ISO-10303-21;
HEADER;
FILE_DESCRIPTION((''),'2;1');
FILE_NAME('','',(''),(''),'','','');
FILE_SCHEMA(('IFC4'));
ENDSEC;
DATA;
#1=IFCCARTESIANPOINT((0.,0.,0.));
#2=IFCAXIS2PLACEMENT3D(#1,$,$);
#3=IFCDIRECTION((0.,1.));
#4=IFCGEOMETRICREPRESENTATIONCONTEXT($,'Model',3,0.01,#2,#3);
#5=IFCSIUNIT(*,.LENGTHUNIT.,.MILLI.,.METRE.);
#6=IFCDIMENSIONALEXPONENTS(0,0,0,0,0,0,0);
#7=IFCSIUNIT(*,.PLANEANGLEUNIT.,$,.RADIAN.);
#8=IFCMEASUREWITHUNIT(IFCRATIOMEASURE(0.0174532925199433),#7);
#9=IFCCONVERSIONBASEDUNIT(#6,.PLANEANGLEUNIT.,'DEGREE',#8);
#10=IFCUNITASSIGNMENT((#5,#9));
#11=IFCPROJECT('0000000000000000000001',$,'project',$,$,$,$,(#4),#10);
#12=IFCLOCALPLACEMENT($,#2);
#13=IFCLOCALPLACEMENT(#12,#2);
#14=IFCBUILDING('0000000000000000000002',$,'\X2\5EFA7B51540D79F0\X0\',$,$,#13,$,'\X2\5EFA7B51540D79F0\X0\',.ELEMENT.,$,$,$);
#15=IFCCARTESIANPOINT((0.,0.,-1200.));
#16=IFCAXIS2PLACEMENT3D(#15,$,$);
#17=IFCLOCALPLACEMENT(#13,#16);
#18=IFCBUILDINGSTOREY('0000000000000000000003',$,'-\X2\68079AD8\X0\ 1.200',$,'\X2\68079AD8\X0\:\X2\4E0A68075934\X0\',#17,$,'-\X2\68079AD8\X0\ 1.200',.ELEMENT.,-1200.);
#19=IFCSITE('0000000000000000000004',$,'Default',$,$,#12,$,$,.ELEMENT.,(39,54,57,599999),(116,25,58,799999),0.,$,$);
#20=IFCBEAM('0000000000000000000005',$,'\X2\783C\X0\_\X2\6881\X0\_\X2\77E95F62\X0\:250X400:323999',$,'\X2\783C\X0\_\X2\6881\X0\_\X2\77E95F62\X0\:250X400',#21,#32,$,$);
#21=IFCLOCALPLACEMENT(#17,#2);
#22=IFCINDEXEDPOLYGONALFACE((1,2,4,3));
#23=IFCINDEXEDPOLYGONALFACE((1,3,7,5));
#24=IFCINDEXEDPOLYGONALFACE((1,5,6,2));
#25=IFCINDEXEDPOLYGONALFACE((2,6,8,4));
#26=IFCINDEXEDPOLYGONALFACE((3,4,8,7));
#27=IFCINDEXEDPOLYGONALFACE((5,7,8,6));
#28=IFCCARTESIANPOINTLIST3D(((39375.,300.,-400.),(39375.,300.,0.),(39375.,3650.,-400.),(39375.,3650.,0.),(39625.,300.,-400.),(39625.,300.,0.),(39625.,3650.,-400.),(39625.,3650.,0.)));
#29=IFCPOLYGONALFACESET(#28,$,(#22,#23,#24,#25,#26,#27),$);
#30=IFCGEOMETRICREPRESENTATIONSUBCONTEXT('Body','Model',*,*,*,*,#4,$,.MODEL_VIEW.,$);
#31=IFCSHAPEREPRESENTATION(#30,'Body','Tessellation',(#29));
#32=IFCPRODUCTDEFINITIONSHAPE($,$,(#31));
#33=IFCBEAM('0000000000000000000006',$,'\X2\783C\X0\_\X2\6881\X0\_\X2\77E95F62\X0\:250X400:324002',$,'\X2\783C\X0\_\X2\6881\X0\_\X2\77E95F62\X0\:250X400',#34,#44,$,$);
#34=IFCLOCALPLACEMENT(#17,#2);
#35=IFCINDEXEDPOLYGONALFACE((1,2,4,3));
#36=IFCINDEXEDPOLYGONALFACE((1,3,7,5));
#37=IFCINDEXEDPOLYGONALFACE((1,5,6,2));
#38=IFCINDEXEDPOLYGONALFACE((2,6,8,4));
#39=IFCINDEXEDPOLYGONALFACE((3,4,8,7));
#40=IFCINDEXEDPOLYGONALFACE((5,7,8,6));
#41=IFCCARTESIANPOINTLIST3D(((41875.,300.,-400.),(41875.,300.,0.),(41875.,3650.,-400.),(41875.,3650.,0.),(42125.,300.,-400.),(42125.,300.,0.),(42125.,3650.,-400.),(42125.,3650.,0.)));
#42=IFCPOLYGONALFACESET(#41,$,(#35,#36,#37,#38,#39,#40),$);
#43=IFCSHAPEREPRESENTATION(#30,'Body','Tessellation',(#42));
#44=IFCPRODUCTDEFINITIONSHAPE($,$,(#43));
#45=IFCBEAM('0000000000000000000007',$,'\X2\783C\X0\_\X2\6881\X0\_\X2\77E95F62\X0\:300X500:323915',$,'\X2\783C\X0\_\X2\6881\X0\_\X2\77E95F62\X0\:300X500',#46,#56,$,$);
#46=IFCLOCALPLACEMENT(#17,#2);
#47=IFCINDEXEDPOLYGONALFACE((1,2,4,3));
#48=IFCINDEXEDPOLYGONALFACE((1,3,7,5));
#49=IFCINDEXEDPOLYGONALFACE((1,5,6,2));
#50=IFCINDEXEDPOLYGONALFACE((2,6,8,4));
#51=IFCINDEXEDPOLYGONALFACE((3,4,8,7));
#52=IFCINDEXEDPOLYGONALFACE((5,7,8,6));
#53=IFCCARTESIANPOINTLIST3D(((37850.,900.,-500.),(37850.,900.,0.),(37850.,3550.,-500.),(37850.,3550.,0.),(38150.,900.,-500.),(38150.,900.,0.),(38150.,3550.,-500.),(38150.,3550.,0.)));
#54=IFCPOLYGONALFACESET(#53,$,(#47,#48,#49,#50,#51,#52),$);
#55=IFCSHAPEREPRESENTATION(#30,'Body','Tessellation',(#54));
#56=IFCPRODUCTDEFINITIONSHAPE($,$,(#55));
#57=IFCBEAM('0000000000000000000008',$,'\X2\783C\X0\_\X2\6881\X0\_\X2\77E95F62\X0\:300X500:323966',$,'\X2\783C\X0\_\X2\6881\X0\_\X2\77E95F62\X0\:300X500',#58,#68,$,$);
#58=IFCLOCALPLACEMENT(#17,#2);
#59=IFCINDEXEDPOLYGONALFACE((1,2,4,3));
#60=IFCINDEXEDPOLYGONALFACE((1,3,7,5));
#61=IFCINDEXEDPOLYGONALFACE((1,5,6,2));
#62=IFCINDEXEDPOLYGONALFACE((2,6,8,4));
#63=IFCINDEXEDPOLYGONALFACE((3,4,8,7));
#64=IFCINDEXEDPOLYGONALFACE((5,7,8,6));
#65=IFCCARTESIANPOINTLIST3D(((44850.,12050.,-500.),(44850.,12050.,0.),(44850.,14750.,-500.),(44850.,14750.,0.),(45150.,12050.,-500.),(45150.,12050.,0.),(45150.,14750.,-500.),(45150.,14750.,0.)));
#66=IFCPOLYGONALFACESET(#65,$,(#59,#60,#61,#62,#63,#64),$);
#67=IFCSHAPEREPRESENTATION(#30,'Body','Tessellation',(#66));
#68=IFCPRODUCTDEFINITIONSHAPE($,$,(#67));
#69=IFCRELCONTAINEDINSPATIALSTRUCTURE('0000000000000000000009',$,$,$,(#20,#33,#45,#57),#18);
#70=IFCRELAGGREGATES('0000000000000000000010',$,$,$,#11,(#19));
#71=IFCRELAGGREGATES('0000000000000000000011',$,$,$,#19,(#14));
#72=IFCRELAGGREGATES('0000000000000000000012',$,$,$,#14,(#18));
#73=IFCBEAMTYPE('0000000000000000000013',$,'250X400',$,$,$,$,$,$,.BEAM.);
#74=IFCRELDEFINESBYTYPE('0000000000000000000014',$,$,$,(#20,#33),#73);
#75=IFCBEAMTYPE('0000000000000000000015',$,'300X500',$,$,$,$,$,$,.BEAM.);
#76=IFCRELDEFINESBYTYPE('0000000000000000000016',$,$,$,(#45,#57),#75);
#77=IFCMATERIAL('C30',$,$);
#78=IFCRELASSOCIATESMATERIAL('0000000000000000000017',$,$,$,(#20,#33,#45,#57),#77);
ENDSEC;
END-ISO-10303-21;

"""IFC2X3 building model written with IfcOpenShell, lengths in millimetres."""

from ifc_helpers import new_model, entity, si_unit, converted_unit, direction, frame, frame_2d, origin, place, context, subcontext, project, spatial, rectangle, extrude, material, type_object, element, save


model = new_model("IFC2X3")

# Units and contexts
model_context = context("Model", 3, precision=0.01, world=origin(), true_north=direction((0.0, 1.0)))
body_context = subcontext(model_context, "Body", "Model", "MODEL_VIEW")
ifc_project = project(units=[si_unit("LENGTHUNIT", "METRE", prefix="MILLI"), converted_unit("PLANEANGLEUNIT", "DEGREE", entity("IfcRatioMeasure", 0.0174532925199433), si_unit("PLANEANGLEUNIT", "RADIAN"), dimensions=[0, 0, 0, 0, 0, 0, 0])], contexts=[model_context])

# Site, building, storey
site_placement = place(None, origin())
site = spatial("IfcSite", under=ifc_project, at=site_placement, Name="Default", CompositionType="ELEMENT", RefLatitude=(39, 54, 57, 599999), RefLongitude=(116, 25, 58, 799999), RefElevation=0.0)
building_placement = place(site_placement, origin())
building = spatial("IfcBuilding", under=site, at=building_placement, Name="建筑名称", LongName="建筑名称", CompositionType="ELEMENT")
storey_placement = place(building_placement, frame((0.0, 0.0, -1200.0)))
storey = spatial("IfcBuildingStorey", under=building, at=storey_placement, Name="-标高 1.200", ObjectType="标高:上标头", LongName="-标高 1.200", CompositionType="ELEMENT", Elevation=-1200.0)

# Beams
ifc_material_1 = material(Name="C30")
beam_type_1 = type_object("IfcBeamType", Name="250X400", PredefinedType="BEAM")
beam_1_placement = place(storey_placement, frame((39500.0, 0.0, 0.0), z_axis=(0.0, 0.0, 1.0), x_axis=(0.0, 1.0, 0.0)))
element("IfcBeam", 1, at=beam_1_placement, inside=storey, type_object=beam_type_1, material=ifc_material_1, Name="砼_梁_矩形:250X400:323999", ObjectType="砼_梁_矩形:250X400", context=body_context, shape_type="SweptSolid", body=[
    extrude(rectangle(XDim=400.0, YDim=250.0, at=frame_2d((0.0, 0.0), x_axis=(1.0, 0.0))), frame((300.0, 0.0, -200.0), z_axis=(1.0, 0.0, 0.0), x_axis=(0.0, 0.0, -1.0)), (0.0, 0.0, 1.0), 3350.0),
])
beam_2_placement = place(storey_placement, frame((42000.0, 0.0, 0.0), z_axis=(0.0, 0.0, 1.0), x_axis=(0.0, 1.0, 0.0)))
element("IfcBeam", 2, at=beam_2_placement, inside=storey, type_object=beam_type_1, material=ifc_material_1, Name="砼_梁_矩形:250X400:324002", ObjectType="砼_梁_矩形:250X400", context=body_context, shape_type="SweptSolid", body=[
    extrude(rectangle(XDim=400.0, YDim=250.0, at=frame_2d((0.0, 0.0), x_axis=(1.0, 0.0))), frame((300.0, 0.0, -200.0), z_axis=(1.0, 0.0, 0.0), x_axis=(0.0, 0.0, -1.0)), (0.0, 0.0, 1.0), 3350.0),
])
beam_type_2 = type_object("IfcBeamType", Name="300X500", PredefinedType="BEAM")
beam_3_placement = place(storey_placement, frame((38000.0, 150.0, 0.0), z_axis=(0.0, 0.0, 1.0), x_axis=(0.0, 1.0, 0.0)))
element("IfcBeam", 3, at=beam_3_placement, inside=storey, type_object=beam_type_2, material=ifc_material_1, Name="砼_梁_矩形:300X500:323915", ObjectType="砼_梁_矩形:300X500", context=body_context, shape_type="SweptSolid", body=[
    extrude(rectangle(XDim=500.0, YDim=300.0, at=frame_2d((0.0, 0.0), x_axis=(1.0, 0.0))), frame((750.0, 0.0, -250.0), z_axis=(1.0, 0.0, 0.0), x_axis=(0.0, 0.0, -1.0)), (0.0, 0.0, 1.0), 2650.0),
])
beam_4_placement = place(storey_placement, frame((45000.0, 11900.0, 0.0), z_axis=(0.0, 0.0, 1.0), x_axis=(0.0, 1.0, 0.0)))
element("IfcBeam", 4, at=beam_4_placement, inside=storey, type_object=beam_type_2, material=ifc_material_1, Name="砼_梁_矩形:300X500:323966", ObjectType="砼_梁_矩形:300X500", context=body_context, shape_type="SweptSolid", body=[
    extrude(rectangle(XDim=500.0, YDim=300.0, at=frame_2d((0.0, 0.0), x_axis=(1.0, 0.0))), frame((150.0, 0.0, -250.0), z_axis=(1.0, 0.0, 0.0), x_axis=(0.0, 0.0, -1.0)), (0.0, 0.0, 1.0), 2700.0),
])

save(model, "model.ifc")
